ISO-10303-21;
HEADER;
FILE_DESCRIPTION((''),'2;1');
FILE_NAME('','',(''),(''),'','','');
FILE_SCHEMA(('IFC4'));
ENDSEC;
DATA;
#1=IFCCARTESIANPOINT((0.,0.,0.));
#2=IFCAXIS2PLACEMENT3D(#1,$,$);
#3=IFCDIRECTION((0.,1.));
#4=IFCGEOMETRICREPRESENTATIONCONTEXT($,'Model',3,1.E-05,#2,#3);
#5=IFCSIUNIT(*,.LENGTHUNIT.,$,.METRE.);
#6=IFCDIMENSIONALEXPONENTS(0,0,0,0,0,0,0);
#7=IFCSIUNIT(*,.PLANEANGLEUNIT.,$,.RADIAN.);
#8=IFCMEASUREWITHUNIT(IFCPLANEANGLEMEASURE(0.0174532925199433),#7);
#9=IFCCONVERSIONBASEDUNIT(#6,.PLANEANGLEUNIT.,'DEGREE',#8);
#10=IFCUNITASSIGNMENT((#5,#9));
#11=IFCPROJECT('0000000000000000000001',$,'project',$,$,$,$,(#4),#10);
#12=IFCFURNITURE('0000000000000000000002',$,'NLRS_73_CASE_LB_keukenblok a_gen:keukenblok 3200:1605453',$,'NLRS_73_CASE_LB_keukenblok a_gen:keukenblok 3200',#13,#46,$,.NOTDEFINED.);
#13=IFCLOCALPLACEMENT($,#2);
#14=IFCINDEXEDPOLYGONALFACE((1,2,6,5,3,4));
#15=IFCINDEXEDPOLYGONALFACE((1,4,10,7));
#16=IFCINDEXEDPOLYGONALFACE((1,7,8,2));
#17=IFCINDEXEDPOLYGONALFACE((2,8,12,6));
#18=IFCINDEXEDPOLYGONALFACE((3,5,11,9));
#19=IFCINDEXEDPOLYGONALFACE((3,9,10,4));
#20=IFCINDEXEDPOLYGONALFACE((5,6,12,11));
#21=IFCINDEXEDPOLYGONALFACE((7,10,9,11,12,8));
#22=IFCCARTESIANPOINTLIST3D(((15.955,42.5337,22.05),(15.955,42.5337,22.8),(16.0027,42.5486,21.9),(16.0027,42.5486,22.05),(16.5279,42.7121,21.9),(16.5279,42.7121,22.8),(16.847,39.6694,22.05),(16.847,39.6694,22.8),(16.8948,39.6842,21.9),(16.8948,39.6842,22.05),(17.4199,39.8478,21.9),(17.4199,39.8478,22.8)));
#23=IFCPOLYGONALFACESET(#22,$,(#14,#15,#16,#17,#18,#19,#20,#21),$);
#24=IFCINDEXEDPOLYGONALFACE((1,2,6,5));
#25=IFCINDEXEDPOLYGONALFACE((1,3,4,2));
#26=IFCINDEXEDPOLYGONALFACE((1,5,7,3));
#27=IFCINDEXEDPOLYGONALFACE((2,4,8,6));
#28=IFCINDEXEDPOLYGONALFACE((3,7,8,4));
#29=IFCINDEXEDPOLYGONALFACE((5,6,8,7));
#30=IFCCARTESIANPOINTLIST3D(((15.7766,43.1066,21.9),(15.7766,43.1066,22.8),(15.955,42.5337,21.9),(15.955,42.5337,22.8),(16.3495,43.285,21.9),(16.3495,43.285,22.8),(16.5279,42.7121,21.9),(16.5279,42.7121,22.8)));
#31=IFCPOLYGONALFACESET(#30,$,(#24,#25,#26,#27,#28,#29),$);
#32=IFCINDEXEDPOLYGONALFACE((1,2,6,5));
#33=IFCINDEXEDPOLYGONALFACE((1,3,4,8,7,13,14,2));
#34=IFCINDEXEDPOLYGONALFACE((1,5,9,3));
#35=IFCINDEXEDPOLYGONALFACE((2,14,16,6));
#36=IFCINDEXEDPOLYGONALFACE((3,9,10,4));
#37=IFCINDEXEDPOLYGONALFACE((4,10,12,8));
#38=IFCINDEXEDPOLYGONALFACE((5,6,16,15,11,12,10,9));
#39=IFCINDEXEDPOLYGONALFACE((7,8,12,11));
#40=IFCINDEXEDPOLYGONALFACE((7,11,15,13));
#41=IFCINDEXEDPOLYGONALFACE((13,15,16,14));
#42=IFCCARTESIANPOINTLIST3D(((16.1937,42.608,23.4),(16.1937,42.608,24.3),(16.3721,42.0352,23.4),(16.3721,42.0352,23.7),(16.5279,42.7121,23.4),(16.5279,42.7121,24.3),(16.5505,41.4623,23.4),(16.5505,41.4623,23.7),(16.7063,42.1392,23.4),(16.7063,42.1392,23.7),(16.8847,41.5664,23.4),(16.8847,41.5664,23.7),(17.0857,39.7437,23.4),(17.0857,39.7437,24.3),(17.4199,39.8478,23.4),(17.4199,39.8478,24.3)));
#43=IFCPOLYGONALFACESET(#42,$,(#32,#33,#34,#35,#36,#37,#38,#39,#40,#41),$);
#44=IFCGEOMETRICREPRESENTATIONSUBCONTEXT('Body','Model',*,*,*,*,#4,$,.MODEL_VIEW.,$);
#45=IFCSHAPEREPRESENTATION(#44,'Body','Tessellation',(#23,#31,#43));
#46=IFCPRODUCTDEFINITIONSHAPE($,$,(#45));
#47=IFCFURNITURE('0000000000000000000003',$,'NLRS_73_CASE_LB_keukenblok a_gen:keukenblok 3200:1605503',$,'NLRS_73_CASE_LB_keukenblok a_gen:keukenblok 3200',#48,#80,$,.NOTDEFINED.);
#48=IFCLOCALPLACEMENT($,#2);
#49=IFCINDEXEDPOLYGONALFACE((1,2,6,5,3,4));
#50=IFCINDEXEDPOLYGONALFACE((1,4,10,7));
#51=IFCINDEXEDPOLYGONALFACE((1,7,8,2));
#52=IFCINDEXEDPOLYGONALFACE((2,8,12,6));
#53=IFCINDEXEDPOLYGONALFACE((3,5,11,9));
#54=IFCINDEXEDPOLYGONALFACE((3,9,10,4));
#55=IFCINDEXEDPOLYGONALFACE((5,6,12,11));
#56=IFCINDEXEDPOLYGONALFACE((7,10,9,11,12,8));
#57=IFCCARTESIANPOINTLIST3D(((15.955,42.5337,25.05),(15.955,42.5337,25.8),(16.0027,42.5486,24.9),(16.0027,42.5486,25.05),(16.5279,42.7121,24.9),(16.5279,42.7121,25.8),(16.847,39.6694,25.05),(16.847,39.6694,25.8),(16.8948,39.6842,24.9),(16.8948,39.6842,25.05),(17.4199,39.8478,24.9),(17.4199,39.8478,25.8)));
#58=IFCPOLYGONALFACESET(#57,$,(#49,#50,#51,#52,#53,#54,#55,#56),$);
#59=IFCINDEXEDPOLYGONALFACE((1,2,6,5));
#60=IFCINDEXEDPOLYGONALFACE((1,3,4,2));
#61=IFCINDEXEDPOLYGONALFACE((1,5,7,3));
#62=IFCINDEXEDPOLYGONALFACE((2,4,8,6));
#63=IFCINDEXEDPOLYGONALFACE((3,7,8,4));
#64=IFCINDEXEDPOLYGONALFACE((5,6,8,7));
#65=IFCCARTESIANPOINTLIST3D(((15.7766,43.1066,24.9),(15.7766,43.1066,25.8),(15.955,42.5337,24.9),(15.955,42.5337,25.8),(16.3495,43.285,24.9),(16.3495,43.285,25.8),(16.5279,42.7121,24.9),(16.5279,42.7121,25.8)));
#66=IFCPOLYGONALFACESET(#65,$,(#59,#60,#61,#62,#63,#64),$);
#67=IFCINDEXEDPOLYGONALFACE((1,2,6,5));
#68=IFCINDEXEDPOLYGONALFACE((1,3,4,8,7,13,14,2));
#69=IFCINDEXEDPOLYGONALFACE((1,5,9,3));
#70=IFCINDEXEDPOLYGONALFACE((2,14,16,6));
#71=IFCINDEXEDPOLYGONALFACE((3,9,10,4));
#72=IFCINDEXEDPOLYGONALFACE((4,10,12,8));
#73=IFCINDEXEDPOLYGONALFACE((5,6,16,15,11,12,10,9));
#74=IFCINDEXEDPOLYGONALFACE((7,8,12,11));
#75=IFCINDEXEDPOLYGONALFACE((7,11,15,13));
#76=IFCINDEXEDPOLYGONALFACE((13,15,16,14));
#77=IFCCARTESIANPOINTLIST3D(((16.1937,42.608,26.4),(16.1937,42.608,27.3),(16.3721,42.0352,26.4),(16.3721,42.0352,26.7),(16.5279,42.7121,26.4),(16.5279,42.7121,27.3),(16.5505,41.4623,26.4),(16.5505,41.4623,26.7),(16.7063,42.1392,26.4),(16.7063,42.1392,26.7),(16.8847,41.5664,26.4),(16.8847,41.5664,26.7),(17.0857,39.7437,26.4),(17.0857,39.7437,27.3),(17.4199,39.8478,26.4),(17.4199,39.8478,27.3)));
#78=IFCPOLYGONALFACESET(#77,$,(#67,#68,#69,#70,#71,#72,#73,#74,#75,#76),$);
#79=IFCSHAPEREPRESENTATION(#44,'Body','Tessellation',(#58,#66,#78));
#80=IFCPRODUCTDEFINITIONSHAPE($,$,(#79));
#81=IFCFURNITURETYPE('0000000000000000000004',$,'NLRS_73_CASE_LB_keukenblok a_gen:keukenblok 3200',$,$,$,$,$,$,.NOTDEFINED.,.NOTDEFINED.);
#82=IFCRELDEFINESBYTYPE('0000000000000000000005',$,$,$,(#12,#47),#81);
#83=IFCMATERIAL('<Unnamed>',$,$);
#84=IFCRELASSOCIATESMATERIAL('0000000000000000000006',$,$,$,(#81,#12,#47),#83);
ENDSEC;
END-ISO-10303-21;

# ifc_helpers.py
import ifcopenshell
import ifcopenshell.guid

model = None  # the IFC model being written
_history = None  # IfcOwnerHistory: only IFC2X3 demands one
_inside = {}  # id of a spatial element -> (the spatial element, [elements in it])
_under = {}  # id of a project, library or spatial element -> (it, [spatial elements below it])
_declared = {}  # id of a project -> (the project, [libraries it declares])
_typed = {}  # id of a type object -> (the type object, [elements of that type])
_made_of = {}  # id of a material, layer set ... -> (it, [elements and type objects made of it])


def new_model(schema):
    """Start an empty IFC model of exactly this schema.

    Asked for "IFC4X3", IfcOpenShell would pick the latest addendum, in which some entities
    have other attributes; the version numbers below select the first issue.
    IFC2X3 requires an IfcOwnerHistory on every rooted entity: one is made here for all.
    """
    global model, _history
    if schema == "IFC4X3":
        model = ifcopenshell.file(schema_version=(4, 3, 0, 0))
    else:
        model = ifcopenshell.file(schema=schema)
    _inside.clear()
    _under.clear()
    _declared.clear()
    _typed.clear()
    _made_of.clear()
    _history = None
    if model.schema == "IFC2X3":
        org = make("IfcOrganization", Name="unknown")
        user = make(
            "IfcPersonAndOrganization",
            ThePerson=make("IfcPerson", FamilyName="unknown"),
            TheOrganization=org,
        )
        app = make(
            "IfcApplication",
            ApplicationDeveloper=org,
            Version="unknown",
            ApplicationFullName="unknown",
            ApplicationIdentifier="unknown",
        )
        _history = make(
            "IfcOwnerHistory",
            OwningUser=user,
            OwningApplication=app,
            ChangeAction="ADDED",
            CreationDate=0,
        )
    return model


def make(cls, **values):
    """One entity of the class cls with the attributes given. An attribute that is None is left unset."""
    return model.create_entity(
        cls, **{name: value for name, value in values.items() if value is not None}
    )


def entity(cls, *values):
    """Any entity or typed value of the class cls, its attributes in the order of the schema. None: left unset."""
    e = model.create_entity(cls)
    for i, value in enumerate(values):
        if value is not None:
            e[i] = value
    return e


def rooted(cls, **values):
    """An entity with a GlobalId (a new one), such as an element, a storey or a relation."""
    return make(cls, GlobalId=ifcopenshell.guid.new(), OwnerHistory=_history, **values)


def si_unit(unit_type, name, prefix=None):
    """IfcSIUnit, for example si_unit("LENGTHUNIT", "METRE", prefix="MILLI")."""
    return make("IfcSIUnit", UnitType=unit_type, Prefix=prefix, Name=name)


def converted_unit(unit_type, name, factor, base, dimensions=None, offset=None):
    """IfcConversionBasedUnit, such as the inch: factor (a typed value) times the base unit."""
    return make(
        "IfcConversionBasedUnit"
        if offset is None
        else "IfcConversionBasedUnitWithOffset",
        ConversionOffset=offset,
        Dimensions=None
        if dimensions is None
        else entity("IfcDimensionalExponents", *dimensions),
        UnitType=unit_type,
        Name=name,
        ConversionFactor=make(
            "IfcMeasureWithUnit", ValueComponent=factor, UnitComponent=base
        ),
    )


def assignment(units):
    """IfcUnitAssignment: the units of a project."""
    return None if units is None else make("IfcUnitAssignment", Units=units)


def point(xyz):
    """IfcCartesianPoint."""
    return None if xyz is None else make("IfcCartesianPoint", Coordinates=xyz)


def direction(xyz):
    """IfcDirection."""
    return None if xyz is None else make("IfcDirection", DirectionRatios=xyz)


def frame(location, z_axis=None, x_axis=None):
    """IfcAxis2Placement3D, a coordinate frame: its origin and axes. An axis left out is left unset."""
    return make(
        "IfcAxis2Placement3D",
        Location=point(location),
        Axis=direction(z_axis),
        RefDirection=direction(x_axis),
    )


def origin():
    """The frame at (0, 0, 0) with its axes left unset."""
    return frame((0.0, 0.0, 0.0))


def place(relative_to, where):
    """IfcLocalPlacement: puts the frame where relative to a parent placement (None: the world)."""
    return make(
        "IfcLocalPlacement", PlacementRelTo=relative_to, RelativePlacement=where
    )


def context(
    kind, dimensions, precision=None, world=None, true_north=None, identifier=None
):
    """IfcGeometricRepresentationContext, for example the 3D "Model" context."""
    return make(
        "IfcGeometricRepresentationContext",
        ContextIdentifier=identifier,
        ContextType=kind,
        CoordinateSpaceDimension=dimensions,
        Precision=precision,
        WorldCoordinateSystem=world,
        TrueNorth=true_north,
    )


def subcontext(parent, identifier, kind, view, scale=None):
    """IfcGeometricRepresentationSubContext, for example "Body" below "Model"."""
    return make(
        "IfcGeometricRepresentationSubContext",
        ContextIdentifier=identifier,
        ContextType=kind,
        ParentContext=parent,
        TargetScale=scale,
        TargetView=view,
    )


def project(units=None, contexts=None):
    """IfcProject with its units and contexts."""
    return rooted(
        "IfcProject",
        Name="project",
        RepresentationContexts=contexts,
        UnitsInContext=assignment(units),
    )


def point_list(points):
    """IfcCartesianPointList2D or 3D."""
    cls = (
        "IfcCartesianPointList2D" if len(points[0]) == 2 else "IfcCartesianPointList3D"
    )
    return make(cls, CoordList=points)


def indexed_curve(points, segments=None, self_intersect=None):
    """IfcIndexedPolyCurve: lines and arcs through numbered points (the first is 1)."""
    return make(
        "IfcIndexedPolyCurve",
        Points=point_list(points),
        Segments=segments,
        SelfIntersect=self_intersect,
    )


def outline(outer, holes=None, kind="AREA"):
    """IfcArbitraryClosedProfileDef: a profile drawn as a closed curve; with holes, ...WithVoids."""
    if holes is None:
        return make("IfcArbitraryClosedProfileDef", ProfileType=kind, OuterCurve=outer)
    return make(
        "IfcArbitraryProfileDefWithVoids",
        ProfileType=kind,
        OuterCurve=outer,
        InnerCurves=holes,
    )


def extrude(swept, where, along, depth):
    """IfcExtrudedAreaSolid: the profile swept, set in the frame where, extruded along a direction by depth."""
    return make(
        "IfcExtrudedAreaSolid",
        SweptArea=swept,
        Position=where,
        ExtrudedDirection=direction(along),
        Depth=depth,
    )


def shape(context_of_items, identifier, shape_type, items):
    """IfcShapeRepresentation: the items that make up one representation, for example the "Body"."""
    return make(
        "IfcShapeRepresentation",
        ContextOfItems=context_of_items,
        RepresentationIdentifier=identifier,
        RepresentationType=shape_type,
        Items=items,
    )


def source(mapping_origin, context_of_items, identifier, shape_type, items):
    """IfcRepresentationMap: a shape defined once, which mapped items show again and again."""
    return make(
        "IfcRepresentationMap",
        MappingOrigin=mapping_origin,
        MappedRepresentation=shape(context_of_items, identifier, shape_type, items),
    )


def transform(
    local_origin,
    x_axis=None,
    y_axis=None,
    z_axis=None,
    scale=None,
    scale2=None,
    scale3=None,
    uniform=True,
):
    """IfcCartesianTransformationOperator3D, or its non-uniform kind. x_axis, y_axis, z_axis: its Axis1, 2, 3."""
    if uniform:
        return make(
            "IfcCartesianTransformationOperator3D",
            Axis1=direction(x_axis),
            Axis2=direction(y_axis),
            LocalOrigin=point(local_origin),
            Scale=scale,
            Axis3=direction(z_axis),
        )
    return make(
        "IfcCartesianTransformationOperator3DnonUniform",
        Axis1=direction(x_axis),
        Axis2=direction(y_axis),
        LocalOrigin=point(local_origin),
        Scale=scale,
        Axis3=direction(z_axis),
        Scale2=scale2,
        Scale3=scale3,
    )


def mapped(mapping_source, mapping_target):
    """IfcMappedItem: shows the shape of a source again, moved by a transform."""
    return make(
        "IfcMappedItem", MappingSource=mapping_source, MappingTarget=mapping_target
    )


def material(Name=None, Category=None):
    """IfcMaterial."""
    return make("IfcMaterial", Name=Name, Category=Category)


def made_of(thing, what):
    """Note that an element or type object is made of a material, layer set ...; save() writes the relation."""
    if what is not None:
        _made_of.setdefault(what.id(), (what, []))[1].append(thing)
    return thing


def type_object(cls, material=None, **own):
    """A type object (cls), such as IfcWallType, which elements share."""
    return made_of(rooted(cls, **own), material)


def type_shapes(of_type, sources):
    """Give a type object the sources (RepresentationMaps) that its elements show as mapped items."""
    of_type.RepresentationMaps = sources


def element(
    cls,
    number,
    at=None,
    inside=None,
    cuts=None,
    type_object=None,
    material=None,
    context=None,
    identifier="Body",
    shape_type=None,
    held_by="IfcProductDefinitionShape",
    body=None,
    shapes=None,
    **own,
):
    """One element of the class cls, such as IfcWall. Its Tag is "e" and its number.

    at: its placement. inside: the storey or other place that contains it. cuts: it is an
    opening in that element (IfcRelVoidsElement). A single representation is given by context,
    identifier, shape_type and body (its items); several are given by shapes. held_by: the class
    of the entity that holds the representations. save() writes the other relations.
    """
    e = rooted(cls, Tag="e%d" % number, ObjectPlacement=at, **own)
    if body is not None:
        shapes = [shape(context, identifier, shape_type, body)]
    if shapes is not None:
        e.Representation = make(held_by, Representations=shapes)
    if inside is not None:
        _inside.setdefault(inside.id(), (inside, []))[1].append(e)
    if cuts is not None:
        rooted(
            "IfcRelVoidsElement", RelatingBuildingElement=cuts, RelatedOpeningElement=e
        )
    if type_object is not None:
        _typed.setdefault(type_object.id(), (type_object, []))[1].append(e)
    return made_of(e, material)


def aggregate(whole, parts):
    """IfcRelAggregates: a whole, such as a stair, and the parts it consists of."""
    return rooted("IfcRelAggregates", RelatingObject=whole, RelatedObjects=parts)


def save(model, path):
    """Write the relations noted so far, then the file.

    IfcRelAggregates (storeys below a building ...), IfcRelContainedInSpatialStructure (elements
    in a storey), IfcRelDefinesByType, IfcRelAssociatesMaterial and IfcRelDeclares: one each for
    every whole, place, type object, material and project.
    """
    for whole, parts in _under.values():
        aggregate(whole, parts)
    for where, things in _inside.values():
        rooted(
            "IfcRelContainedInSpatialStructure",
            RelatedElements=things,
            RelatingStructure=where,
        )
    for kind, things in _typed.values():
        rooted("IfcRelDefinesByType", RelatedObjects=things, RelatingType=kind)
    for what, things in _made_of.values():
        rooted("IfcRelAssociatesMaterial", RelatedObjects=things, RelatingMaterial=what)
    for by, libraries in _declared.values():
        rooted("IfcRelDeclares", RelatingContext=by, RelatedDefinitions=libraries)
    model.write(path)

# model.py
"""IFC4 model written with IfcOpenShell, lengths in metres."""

from ifc_helpers import new_model, entity, si_unit, converted_unit, direction, frame, origin, place, context, subcontext, project, indexed_curve, outline, extrude, source, transform, mapped, material, type_object, type_shapes, element, save


model = new_model("IFC4")

# Units and contexts
model_context = context("Model", 3, precision=1e-05, world=origin(), true_north=direction((0.0, 1.0)))
body_context = subcontext(model_context, "Body", "Model", "MODEL_VIEW")
ifc_project = project(units=[si_unit("LENGTHUNIT", "METRE"), converted_unit("PLANEANGLEUNIT", "DEGREE", entity("IfcPlaneAngleMeasure", 0.0174532925199433), si_unit("PLANEANGLEUNIT", "RADIAN"), dimensions=[0, 0, 0, 0, 0, 0, 0])], contexts=[model_context])

# Shared definitions
ifc_material = material(Name="<Unnamed>")
placement_1 = place(None, frame((13.1348, 11.9886, 0.0), z_axis=(0.0, 0.0, 1.0), x_axis=(0.954771, 0.297342, 0.0)))
placement_2 = place(placement_1, origin())
placement_3 = place(placement_2, frame((0.0, 0.0, 21.9)))
placement_4 = place(placement_2, frame((0.0, 0.0, 24.9)))

# Furniture
furniture_type = type_object("IfcFurnitureType", Name="NLRS_73_CASE_LB_keukenblok a_gen:keukenblok 3200", AssemblyPlace="NOTDEFINED", PredefinedType="NOTDEFINED", material=ifc_material)
shared_shape_1 = source(origin(), body_context, "Body", "SweptSolid", [
    extrude(outline(indexed_curve([(-0.35, 0.1667), (-0.35, -0.3833), (0.55, -0.3833), (0.55, 0.2167), (-0.2, 0.2167), (-0.2, 0.1667), (-0.35, 0.1667)], self_intersect=False)), frame((0.0, 0.3833, 0.35), z_axis=(-1.0, 0.0, 0.0), x_axis=(0.0, 0.0, 1.0)), (0.0, 0.0, -1.0), 3.0),
    extrude(outline(indexed_curve([(-0.3, -0.3), (0.3, -0.3), (0.3, 0.3), (-0.3, 0.3), (-0.3, -0.3)], self_intersect=False)), frame((3.3, 0.3, 0.0), z_axis=(0.0, 0.0, 1.0), x_axis=(0.0, 1.0, 0.0)), (0.0, 0.0, 1.0), 0.9),
    extrude(outline(indexed_curve([(-1.2, -0.3), (-0.6, -0.3), (-0.6, 0.0), (0.0, 0.0), (0.0, -0.3), (1.8, -0.3), (1.8, 0.6), (-1.2, 0.6), (-1.2, -0.3)], self_intersect=False)), frame((1.8, 0.0, 1.8), z_axis=(0.0, 1.0, 0.0), x_axis=(-1.0, 0.0, 0.0)), (0.0, 0.0, 1.0), 0.35),
])
type_shapes(furniture_type, [shared_shape_1])
placement_5 = place(placement_3, origin())
furniture_1_placement = place(placement_5, frame((12.375, 25.325, 0.0), z_axis=(0.0, 0.0, 1.0), x_axis=(0.0, 1.0, 0.0)))
element("IfcFurniture", 1, at=furniture_1_placement, type_object=furniture_type, material=ifc_material, Name="NLRS_73_CASE_LB_keukenblok a_gen:keukenblok 3200:1605453", ObjectType="NLRS_73_CASE_LB_keukenblok a_gen:keukenblok 3200", PredefinedType="NOTDEFINED", context=body_context, shape_type="MappedRepresentation", body=[
    mapped(shared_shape_1, transform((0.0, 0.0, 0.0), scale=1.0)),
])
placement_6 = place(placement_4, origin())
furniture_2_placement = place(placement_6, frame((12.375, 25.325, 0.0), z_axis=(0.0, 0.0, 1.0), x_axis=(0.0, 1.0, 0.0)))
element("IfcFurniture", 2, at=furniture_2_placement, type_object=furniture_type, material=ifc_material, Name="NLRS_73_CASE_LB_keukenblok a_gen:keukenblok 3200:1605503", ObjectType="NLRS_73_CASE_LB_keukenblok a_gen:keukenblok 3200", PredefinedType="NOTDEFINED", context=body_context, shape_type="MappedRepresentation", body=[
    mapped(shared_shape_1, transform((0.0, 0.0, 0.0), scale=1.0)),
])

save(model, "model.ifc")
